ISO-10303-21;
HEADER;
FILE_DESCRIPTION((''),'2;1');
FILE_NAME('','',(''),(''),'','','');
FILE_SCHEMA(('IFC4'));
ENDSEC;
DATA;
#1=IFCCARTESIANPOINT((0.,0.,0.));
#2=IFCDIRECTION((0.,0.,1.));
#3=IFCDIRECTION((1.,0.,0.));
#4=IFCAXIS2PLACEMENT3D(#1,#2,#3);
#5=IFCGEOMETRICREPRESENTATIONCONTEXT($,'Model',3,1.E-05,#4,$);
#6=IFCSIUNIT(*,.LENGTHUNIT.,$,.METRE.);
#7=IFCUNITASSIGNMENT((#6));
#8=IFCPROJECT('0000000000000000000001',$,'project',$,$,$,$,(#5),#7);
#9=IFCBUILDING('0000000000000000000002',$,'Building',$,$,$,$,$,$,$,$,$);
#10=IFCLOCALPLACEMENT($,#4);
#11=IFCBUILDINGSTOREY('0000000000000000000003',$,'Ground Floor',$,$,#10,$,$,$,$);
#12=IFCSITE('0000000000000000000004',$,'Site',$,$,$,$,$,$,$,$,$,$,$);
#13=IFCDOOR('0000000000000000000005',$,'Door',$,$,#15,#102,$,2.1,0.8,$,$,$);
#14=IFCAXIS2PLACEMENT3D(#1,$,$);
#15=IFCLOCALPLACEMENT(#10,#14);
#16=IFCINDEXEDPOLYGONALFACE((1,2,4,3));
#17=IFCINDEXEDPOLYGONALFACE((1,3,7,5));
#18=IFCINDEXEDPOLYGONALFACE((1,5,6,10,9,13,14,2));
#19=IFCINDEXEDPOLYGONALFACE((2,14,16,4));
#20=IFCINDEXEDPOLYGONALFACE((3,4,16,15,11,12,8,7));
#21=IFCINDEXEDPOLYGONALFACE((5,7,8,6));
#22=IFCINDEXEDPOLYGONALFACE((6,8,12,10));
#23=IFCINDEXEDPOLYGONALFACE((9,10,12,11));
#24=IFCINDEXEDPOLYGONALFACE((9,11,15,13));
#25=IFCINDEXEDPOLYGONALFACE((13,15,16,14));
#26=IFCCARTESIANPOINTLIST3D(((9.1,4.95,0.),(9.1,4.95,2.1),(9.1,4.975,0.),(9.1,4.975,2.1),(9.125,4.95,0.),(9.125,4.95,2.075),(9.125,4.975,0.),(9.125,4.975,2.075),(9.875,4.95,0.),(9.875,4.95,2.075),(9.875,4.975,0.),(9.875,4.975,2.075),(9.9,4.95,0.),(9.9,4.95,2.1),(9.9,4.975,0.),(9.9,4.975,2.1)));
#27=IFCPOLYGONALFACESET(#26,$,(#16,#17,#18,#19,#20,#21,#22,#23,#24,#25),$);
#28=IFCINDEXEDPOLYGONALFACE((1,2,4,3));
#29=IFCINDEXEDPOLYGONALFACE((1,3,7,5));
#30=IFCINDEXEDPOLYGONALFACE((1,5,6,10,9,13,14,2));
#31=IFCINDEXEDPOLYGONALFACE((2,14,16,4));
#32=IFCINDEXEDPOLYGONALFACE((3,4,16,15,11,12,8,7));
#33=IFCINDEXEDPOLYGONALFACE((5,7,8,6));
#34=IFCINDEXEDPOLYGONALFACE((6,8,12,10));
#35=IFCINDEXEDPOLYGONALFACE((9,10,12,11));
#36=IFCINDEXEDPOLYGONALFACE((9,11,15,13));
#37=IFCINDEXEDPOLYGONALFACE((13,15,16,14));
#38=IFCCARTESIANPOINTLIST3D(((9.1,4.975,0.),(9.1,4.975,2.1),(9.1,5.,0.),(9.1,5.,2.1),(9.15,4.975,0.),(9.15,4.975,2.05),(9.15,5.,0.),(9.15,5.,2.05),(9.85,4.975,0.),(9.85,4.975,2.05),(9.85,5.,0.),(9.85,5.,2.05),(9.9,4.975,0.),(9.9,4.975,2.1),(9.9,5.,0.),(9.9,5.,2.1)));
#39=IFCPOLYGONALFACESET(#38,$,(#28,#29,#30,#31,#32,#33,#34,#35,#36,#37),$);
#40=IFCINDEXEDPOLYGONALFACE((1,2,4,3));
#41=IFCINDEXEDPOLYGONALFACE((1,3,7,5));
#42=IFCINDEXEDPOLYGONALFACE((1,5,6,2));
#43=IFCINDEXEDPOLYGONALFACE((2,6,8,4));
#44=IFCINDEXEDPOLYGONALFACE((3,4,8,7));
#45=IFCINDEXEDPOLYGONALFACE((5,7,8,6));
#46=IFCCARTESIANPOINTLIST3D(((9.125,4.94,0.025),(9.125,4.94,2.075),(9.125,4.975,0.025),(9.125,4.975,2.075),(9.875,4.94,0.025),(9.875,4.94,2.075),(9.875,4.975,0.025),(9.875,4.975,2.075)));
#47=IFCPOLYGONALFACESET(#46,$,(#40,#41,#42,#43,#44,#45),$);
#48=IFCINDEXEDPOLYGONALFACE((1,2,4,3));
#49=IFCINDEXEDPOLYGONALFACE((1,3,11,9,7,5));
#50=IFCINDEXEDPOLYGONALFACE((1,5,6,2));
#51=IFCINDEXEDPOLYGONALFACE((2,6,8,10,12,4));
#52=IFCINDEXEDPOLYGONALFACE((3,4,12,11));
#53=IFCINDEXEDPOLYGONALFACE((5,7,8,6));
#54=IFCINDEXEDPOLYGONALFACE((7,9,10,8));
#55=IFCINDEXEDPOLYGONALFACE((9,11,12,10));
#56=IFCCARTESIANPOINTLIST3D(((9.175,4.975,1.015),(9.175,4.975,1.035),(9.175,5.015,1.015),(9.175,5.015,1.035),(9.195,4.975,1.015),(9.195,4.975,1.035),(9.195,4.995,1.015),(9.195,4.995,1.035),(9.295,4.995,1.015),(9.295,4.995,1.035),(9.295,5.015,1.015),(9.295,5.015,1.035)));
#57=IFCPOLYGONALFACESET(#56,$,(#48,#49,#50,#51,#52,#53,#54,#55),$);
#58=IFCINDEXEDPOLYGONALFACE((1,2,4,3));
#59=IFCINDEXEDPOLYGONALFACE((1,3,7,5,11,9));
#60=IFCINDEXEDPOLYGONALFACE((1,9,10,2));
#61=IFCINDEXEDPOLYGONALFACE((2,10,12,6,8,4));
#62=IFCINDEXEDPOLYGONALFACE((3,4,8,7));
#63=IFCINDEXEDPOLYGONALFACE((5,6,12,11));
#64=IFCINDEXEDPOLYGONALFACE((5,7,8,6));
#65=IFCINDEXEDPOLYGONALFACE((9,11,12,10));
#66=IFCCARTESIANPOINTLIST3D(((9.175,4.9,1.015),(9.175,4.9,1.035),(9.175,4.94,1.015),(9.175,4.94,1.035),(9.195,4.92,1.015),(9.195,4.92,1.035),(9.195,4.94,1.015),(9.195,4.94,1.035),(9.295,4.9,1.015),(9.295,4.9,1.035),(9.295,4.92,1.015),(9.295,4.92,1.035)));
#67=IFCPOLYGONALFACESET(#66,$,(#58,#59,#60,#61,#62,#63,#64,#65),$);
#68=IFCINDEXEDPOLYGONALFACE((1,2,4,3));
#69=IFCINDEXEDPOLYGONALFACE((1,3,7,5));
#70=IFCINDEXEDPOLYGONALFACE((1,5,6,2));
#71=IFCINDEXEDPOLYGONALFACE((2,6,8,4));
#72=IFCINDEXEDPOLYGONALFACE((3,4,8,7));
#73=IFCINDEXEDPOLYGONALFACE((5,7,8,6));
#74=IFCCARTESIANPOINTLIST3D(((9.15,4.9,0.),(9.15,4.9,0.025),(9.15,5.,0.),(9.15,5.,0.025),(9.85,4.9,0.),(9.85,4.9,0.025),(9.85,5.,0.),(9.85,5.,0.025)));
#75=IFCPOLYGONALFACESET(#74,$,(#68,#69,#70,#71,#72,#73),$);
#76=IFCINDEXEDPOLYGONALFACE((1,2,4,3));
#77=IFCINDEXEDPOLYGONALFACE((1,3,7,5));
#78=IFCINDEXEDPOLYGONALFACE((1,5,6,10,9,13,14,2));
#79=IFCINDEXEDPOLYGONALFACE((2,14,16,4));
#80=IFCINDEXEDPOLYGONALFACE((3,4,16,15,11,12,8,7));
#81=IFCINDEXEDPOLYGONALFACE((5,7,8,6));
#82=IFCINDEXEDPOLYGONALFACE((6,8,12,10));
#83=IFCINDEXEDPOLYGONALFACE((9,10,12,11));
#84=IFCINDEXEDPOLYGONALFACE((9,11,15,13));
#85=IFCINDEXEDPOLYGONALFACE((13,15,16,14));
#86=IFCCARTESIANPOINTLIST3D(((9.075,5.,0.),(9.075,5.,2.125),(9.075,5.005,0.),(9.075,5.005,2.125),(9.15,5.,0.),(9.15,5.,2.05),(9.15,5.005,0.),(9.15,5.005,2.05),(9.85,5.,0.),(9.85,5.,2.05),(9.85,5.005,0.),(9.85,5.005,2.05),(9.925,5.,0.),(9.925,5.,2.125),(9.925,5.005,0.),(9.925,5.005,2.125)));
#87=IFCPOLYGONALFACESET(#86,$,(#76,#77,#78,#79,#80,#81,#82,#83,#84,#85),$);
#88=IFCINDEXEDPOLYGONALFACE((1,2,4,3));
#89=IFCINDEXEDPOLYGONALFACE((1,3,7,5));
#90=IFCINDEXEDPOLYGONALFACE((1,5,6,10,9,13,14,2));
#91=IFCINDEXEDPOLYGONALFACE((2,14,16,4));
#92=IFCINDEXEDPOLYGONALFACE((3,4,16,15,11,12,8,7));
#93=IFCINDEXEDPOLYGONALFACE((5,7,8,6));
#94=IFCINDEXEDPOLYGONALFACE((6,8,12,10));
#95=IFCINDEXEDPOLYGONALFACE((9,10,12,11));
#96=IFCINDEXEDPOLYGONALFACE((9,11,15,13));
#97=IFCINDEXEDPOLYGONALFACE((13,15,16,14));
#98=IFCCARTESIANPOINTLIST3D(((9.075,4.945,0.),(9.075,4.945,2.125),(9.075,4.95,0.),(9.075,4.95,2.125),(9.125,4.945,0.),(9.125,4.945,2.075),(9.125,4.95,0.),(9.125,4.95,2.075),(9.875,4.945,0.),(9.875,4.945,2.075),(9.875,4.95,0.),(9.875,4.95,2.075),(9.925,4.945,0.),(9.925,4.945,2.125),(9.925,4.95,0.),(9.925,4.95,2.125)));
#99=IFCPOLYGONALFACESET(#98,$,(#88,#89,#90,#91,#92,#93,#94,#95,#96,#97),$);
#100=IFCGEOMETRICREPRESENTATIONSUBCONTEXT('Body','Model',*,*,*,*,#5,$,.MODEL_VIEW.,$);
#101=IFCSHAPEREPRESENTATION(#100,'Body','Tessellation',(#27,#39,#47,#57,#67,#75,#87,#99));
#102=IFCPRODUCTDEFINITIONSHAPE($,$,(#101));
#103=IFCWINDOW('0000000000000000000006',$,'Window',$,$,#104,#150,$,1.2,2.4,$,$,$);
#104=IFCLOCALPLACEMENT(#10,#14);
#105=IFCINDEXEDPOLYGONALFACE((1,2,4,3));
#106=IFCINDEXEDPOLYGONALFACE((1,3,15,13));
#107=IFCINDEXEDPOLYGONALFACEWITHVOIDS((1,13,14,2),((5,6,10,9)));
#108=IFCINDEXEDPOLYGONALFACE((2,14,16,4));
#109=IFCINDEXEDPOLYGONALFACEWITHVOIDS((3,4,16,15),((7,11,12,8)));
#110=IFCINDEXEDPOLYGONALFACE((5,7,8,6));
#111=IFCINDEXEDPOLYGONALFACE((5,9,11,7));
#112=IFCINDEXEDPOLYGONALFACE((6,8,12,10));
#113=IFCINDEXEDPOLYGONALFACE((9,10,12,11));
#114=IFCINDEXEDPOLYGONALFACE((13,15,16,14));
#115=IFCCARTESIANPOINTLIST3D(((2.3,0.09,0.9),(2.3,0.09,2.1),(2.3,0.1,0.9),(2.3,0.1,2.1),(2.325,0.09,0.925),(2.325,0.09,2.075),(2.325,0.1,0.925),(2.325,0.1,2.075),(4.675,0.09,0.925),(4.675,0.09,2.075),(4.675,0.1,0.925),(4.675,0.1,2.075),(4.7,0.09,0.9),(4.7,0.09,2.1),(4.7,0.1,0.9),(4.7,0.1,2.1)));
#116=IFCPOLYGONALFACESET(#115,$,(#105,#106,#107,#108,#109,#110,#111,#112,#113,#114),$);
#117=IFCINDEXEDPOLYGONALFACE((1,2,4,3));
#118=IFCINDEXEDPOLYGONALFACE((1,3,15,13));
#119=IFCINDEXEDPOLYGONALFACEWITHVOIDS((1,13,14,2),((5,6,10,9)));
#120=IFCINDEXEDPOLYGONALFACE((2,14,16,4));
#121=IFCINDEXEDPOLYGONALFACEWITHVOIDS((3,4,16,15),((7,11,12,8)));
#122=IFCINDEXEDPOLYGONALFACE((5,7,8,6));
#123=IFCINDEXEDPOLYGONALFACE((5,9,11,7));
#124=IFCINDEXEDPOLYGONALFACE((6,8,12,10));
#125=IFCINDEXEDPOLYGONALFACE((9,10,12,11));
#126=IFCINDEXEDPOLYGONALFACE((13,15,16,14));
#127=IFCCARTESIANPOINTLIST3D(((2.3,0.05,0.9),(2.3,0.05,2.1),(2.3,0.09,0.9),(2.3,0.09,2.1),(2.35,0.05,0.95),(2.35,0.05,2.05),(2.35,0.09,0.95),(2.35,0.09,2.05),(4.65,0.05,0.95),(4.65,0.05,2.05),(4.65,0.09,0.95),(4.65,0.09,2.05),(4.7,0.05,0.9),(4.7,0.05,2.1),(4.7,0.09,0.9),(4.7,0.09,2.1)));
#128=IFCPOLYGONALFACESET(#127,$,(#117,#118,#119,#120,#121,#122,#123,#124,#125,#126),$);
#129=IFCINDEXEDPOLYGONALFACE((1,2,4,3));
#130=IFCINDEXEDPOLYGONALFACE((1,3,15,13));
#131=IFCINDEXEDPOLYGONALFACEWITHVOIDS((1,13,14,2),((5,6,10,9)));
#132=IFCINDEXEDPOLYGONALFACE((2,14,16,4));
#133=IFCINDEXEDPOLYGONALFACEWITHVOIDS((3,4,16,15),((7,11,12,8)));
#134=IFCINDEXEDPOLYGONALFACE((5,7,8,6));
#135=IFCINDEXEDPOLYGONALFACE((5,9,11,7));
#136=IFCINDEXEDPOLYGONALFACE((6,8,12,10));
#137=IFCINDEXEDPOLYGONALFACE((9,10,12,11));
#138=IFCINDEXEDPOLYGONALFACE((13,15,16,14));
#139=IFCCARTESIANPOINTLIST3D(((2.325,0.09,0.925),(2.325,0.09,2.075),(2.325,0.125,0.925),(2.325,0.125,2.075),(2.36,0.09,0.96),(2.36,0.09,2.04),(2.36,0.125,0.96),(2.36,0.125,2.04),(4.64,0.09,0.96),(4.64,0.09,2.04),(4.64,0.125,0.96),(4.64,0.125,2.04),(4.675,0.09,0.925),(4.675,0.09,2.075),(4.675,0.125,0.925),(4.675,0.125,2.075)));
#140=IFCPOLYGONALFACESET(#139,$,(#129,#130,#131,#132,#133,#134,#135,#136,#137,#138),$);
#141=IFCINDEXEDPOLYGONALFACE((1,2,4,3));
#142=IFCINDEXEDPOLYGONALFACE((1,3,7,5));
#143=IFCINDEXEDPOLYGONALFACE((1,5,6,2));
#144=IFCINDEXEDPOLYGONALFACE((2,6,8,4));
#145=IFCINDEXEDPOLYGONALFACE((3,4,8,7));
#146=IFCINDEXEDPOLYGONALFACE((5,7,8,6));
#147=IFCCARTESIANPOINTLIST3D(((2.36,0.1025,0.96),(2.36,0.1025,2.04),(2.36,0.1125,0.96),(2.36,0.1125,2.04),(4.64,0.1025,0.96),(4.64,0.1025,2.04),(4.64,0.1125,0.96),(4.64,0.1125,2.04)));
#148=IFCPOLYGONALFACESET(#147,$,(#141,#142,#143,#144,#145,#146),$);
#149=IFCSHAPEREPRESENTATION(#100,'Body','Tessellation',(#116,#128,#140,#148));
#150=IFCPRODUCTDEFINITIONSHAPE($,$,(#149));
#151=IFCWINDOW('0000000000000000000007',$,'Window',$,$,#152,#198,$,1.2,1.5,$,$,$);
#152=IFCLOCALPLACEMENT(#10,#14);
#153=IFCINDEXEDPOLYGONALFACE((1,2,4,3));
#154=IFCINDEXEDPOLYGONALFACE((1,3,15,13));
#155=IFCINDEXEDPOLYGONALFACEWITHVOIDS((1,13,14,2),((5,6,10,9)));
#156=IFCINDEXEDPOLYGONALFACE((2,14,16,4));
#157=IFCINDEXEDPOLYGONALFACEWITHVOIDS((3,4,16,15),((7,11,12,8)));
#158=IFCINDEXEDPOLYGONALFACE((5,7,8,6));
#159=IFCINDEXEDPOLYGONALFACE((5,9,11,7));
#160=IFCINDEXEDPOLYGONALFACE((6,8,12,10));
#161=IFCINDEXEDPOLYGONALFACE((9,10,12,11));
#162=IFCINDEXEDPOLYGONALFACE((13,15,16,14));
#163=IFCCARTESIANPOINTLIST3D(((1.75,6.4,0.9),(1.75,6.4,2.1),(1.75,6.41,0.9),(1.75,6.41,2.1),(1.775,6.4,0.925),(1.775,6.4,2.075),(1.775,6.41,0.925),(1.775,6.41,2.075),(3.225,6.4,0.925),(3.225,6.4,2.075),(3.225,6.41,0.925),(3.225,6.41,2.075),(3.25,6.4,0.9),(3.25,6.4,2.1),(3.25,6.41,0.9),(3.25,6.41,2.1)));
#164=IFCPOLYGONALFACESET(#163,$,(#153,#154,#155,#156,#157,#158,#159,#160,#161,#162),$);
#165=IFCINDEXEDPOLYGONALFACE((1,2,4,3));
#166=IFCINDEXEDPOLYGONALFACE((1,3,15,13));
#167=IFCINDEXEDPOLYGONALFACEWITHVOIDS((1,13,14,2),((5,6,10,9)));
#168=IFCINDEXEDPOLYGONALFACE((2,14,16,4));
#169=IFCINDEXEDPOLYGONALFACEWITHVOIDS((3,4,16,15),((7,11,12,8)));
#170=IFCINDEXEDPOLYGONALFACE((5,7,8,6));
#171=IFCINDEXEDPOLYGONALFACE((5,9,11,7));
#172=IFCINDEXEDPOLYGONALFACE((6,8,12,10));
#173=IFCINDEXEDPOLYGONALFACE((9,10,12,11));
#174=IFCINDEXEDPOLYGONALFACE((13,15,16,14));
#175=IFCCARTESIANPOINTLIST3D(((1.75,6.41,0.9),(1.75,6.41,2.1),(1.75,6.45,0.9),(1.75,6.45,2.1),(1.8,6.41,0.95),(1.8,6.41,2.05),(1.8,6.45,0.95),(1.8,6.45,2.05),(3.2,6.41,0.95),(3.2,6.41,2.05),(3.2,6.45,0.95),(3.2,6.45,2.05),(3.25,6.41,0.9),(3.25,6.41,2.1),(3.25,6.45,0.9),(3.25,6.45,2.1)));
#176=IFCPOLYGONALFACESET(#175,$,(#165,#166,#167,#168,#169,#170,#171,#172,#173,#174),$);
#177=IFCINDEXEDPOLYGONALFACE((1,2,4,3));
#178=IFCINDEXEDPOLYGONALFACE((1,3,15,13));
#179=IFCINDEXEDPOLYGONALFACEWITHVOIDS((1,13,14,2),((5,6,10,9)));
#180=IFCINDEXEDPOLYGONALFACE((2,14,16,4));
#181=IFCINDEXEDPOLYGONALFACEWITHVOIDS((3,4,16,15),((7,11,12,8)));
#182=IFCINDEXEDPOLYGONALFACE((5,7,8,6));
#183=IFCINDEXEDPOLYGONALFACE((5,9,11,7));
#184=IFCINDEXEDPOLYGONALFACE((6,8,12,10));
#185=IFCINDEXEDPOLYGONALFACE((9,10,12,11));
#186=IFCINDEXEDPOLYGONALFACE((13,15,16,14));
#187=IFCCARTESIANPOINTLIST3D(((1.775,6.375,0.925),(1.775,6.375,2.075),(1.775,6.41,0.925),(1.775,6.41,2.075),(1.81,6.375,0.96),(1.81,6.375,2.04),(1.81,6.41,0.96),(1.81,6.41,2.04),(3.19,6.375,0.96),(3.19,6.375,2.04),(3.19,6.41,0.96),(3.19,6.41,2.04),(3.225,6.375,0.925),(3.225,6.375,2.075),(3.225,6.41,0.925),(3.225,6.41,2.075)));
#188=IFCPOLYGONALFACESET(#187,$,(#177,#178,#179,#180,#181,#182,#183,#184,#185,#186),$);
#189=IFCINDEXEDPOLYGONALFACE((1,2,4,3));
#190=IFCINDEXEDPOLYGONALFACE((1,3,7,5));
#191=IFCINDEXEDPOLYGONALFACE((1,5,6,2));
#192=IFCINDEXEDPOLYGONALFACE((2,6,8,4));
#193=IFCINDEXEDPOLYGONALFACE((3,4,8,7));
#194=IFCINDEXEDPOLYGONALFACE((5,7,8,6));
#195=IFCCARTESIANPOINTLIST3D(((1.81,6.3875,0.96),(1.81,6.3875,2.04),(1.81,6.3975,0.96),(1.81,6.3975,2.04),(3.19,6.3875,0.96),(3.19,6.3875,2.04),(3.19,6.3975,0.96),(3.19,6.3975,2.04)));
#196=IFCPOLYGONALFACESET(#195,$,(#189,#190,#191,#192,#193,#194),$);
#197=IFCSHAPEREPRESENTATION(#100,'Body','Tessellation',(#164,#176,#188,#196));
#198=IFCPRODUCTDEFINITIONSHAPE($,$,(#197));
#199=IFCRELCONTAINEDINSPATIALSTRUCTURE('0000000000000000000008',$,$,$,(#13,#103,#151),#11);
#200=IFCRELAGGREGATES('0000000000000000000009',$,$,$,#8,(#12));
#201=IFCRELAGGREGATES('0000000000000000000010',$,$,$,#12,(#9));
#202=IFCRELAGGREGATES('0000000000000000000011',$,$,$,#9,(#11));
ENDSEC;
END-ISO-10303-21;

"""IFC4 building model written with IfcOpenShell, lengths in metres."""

from ifc_helpers import new_model, si_unit, frame, origin_with_axes, place, context, subcontext, project, spatial, line, indexed_curve, outline, extrude, element, save


model = new_model("IFC4")

# Units and contexts
model_context = context("Model", 3, precision=1e-05, world=origin_with_axes())
body_context = subcontext(model_context, "Body", "Model", "MODEL_VIEW")
ifc_project = project(units=[si_unit("LENGTHUNIT", "METRE")], contexts=[model_context])

# Site, building, storey
site = spatial("IfcSite", under=ifc_project, Name="Site")
building = spatial("IfcBuilding", under=site, Name="Building")
storey_placement = place(None, origin_with_axes())
storey = spatial("IfcBuildingStorey", under=building, at=storey_placement, Name="Ground Floor")

# Door
door_1_placement = place(storey_placement, frame((9.9, 5.0, 0.0), z_axis=(0.0, 0.0, 1.0), x_axis=(-1.0, 0.0, 0.0)))
element("IfcDoor", 1, at=door_1_placement, inside=storey, Name="Door", OverallHeight=2.1, OverallWidth=0.8, context=body_context, shape_type="SweptSolid", body=[
    extrude(outline(indexed_curve([(0.0, 0.0), (0.0, 2.1), (0.8, 2.1), (0.8, 0.0), (0.775, 0.0), (0.775, 2.075), (0.025, 2.075), (0.025, 0.0)], segments=[line(1, 2, 3, 4, 5, 6, 7, 8, 1)])), frame((0.0, 0.025, 0.0), z_axis=(0.0, -1.0, 0.0), x_axis=(1.0, 0.0, 0.0)), (0.0, 0.0, -1.0), 0.025),
    extrude(outline(indexed_curve([(0.0, 0.0), (0.0, 2.1), (0.8, 2.1), (0.8, 0.0), (0.75, 0.0), (0.75, 2.05), (0.05, 2.05), (0.05, 0.0)], segments=[line(1, 2, 3, 4, 5, 6, 7, 8, 1)])), frame((0.0, 0.0, 0.0), z_axis=(0.0, -1.0, 0.0), x_axis=(1.0, 0.0, 0.0)), (0.0, 0.0, -1.0), 0.025),
    extrude(outline(indexed_curve([(0.0, 0.0), (0.75, 0.0), (0.75, 0.035), (0.0, 0.035)], segments=[line(1, 2, 3, 4, 1)])), frame((0.025, 0.025, 0.025), z_axis=(0.0, 0.0, 1.0), x_axis=(1.0, 0.0, 0.0)), (0.0, 0.0, 1.0), 2.05),
    extrude(outline(indexed_curve([(0.0, 0.0), (0.0, -0.04), (-0.12, -0.04), (-0.12, -0.02), (-0.02, -0.02), (-0.02, 0.0)], segments=[line(1, 2, 3, 4, 5, 6, 1)])), frame((0.725, 0.025, 1.015), z_axis=(0.0, 0.0, 1.0), x_axis=(1.0, 0.0, 0.0)), (0.0, 0.0, 1.0), 0.02),
    extrude(outline(indexed_curve([(0.0, 0.0), (0.0, 0.04), (-0.12, 0.04), (-0.12, 0.02), (-0.02, 0.02), (-0.02, 0.0)], segments=[line(1, 2, 3, 4, 5, 6, 1)])), frame((0.725, 0.06, 1.015), z_axis=(0.0, 0.0, 1.0), x_axis=(1.0, 0.0, 0.0)), (0.0, 0.0, 1.0), 0.02),
    extrude(outline(indexed_curve([(0.0, 0.0), (0.7, 0.0), (0.7, 0.1), (0.0, 0.1)], segments=[line(1, 2, 3, 4, 1)])), frame((0.05, 0.0, 0.0), z_axis=(0.0, 0.0, 1.0), x_axis=(1.0, 0.0, 0.0)), (0.0, 0.0, 1.0), 0.025),
    extrude(outline(indexed_curve([(0.0, 0.0), (0.0, 2.125), (0.85, 2.125), (0.85, 0.0), (0.775, 0.0), (0.775, 2.05), (0.075, 2.05), (0.075, 0.0)], segments=[line(1, 2, 3, 4, 5, 6, 7, 8, 1)])), frame((-0.025, -0.005, 0.0), z_axis=(0.0, -1.0, 0.0), x_axis=(1.0, 0.0, 0.0)), (0.0, 0.0, -1.0), 0.005),
    extrude(outline(indexed_curve([(0.0, 0.0), (0.0, 2.125), (0.85, 2.125), (0.85, 0.0), (0.8, 0.0), (0.8, 2.075), (0.05, 2.075), (0.05, 0.0)], segments=[line(1, 2, 3, 4, 5, 6, 7, 8, 1)])), frame((-0.025, 0.05, 0.0), z_axis=(0.0, -1.0, 0.0), x_axis=(1.0, 0.0, 0.0)), (0.0, 0.0, -1.0), 0.005),
])

# Windows
window_1_placement = place(storey_placement, frame((2.3, 0.0, 0.9), z_axis=(0.0, 0.0, 1.0), x_axis=(1.0, 0.0, 0.0)))
element("IfcWindow", 2, at=window_1_placement, inside=storey, Name="Window", OverallHeight=1.2, OverallWidth=2.4, context=body_context, shape_type="SweptSolid", body=[
    extrude(outline(indexed_curve([(0.0, 0.0), (2.4, 0.0), (2.4, 1.2), (0.0, 1.2)], segments=[line(1, 2, 3, 4, 1)]), holes=[indexed_curve([(0.025, 0.025), (2.375, 0.025), (2.375, 1.175), (0.025, 1.175)], segments=[line(1, 2, 3, 4, 1)])]), frame((0.0, 0.09, 0.0), z_axis=(0.0, -1.0, 0.0), x_axis=(1.0, 0.0, 0.0)), (0.0, 0.0, -1.0), 0.01),
    extrude(outline(indexed_curve([(0.0, 0.0), (2.4, 0.0), (2.4, 1.2), (0.0, 1.2)], segments=[line(1, 2, 3, 4, 1)]), holes=[indexed_curve([(0.05, 0.05), (2.35, 0.05), (2.35, 1.15), (0.05, 1.15)], segments=[line(1, 2, 3, 4, 1)])]), frame((0.0, 0.05, 0.0), z_axis=(0.0, -1.0, 0.0), x_axis=(1.0, 0.0, 0.0)), (0.0, 0.0, -1.0), 0.04),
    extrude(outline(indexed_curve([(0.0, 0.0), (2.35, 0.0), (2.35, 1.15), (0.0, 1.15)], segments=[line(1, 2, 3, 4, 1)]), holes=[indexed_curve([(0.035, 0.035), (2.315, 0.035), (2.315, 1.115), (0.035, 1.115)], segments=[line(1, 2, 3, 4, 1)])]), frame((0.025, 0.09, 0.025), z_axis=(0.0, -1.0, 0.0), x_axis=(1.0, 0.0, 0.0)), (0.0, 0.0, -1.0), 0.035),
    extrude(outline(indexed_curve([(0.035, 0.035), (2.315, 0.035), (2.315, 1.115), (0.035, 1.115)], segments=[line(1, 2, 3, 4, 1)])), frame((0.025, 0.1025, 0.025), z_axis=(0.0, -1.0, 0.0), x_axis=(1.0, 0.0, 0.0)), (0.0, 0.0, -1.0), 0.01),
])
window_2_placement = place(storey_placement, frame((3.25, 6.5, 0.9), z_axis=(0.0, 0.0, 1.0), x_axis=(-1.0, 0.0, 0.0)))
element("IfcWindow", 3, at=window_2_placement, inside=storey, Name="Window", OverallHeight=1.2, OverallWidth=1.5, context=body_context, shape_type="SweptSolid", body=[
    extrude(outline(indexed_curve([(0.0, 0.0), (1.5, 0.0), (1.5, 1.2), (0.0, 1.2)], segments=[line(1, 2, 3, 4, 1)]), holes=[indexed_curve([(0.025, 0.025), (1.475, 0.025), (1.475, 1.175), (0.025, 1.175)], segments=[line(1, 2, 3, 4, 1)])]), frame((0.0, 0.09, 0.0), z_axis=(0.0, -1.0, 0.0), x_axis=(1.0, 0.0, 0.0)), (0.0, 0.0, -1.0), 0.01),
    extrude(outline(indexed_curve([(0.0, 0.0), (1.5, 0.0), (1.5, 1.2), (0.0, 1.2)], segments=[line(1, 2, 3, 4, 1)]), holes=[indexed_curve([(0.05, 0.05), (1.45, 0.05), (1.45, 1.15), (0.05, 1.15)], segments=[line(1, 2, 3, 4, 1)])]), frame((0.0, 0.05, 0.0), z_axis=(0.0, -1.0, 0.0), x_axis=(1.0, 0.0, 0.0)), (0.0, 0.0, -1.0), 0.04),
    extrude(outline(indexed_curve([(0.0, 0.0), (1.45, 0.0), (1.45, 1.15), (0.0, 1.15)], segments=[line(1, 2, 3, 4, 1)]), holes=[indexed_curve([(0.035, 0.035), (1.415, 0.035), (1.415, 1.115), (0.035, 1.115)], segments=[line(1, 2, 3, 4, 1)])]), frame((0.025, 0.09, 0.025), z_axis=(0.0, -1.0, 0.0), x_axis=(1.0, 0.0, 0.0)), (0.0, 0.0, -1.0), 0.035),
    extrude(outline(indexed_curve([(0.035, 0.035), (1.415, 0.035), (1.415, 1.115), (0.035, 1.115)], segments=[line(1, 2, 3, 4, 1)])), frame((0.025, 0.1025, 0.025), z_axis=(0.0, -1.0, 0.0), x_axis=(1.0, 0.0, 0.0)), (0.0, 0.0, -1.0), 0.01),
])

save(model, "model.ifc")
